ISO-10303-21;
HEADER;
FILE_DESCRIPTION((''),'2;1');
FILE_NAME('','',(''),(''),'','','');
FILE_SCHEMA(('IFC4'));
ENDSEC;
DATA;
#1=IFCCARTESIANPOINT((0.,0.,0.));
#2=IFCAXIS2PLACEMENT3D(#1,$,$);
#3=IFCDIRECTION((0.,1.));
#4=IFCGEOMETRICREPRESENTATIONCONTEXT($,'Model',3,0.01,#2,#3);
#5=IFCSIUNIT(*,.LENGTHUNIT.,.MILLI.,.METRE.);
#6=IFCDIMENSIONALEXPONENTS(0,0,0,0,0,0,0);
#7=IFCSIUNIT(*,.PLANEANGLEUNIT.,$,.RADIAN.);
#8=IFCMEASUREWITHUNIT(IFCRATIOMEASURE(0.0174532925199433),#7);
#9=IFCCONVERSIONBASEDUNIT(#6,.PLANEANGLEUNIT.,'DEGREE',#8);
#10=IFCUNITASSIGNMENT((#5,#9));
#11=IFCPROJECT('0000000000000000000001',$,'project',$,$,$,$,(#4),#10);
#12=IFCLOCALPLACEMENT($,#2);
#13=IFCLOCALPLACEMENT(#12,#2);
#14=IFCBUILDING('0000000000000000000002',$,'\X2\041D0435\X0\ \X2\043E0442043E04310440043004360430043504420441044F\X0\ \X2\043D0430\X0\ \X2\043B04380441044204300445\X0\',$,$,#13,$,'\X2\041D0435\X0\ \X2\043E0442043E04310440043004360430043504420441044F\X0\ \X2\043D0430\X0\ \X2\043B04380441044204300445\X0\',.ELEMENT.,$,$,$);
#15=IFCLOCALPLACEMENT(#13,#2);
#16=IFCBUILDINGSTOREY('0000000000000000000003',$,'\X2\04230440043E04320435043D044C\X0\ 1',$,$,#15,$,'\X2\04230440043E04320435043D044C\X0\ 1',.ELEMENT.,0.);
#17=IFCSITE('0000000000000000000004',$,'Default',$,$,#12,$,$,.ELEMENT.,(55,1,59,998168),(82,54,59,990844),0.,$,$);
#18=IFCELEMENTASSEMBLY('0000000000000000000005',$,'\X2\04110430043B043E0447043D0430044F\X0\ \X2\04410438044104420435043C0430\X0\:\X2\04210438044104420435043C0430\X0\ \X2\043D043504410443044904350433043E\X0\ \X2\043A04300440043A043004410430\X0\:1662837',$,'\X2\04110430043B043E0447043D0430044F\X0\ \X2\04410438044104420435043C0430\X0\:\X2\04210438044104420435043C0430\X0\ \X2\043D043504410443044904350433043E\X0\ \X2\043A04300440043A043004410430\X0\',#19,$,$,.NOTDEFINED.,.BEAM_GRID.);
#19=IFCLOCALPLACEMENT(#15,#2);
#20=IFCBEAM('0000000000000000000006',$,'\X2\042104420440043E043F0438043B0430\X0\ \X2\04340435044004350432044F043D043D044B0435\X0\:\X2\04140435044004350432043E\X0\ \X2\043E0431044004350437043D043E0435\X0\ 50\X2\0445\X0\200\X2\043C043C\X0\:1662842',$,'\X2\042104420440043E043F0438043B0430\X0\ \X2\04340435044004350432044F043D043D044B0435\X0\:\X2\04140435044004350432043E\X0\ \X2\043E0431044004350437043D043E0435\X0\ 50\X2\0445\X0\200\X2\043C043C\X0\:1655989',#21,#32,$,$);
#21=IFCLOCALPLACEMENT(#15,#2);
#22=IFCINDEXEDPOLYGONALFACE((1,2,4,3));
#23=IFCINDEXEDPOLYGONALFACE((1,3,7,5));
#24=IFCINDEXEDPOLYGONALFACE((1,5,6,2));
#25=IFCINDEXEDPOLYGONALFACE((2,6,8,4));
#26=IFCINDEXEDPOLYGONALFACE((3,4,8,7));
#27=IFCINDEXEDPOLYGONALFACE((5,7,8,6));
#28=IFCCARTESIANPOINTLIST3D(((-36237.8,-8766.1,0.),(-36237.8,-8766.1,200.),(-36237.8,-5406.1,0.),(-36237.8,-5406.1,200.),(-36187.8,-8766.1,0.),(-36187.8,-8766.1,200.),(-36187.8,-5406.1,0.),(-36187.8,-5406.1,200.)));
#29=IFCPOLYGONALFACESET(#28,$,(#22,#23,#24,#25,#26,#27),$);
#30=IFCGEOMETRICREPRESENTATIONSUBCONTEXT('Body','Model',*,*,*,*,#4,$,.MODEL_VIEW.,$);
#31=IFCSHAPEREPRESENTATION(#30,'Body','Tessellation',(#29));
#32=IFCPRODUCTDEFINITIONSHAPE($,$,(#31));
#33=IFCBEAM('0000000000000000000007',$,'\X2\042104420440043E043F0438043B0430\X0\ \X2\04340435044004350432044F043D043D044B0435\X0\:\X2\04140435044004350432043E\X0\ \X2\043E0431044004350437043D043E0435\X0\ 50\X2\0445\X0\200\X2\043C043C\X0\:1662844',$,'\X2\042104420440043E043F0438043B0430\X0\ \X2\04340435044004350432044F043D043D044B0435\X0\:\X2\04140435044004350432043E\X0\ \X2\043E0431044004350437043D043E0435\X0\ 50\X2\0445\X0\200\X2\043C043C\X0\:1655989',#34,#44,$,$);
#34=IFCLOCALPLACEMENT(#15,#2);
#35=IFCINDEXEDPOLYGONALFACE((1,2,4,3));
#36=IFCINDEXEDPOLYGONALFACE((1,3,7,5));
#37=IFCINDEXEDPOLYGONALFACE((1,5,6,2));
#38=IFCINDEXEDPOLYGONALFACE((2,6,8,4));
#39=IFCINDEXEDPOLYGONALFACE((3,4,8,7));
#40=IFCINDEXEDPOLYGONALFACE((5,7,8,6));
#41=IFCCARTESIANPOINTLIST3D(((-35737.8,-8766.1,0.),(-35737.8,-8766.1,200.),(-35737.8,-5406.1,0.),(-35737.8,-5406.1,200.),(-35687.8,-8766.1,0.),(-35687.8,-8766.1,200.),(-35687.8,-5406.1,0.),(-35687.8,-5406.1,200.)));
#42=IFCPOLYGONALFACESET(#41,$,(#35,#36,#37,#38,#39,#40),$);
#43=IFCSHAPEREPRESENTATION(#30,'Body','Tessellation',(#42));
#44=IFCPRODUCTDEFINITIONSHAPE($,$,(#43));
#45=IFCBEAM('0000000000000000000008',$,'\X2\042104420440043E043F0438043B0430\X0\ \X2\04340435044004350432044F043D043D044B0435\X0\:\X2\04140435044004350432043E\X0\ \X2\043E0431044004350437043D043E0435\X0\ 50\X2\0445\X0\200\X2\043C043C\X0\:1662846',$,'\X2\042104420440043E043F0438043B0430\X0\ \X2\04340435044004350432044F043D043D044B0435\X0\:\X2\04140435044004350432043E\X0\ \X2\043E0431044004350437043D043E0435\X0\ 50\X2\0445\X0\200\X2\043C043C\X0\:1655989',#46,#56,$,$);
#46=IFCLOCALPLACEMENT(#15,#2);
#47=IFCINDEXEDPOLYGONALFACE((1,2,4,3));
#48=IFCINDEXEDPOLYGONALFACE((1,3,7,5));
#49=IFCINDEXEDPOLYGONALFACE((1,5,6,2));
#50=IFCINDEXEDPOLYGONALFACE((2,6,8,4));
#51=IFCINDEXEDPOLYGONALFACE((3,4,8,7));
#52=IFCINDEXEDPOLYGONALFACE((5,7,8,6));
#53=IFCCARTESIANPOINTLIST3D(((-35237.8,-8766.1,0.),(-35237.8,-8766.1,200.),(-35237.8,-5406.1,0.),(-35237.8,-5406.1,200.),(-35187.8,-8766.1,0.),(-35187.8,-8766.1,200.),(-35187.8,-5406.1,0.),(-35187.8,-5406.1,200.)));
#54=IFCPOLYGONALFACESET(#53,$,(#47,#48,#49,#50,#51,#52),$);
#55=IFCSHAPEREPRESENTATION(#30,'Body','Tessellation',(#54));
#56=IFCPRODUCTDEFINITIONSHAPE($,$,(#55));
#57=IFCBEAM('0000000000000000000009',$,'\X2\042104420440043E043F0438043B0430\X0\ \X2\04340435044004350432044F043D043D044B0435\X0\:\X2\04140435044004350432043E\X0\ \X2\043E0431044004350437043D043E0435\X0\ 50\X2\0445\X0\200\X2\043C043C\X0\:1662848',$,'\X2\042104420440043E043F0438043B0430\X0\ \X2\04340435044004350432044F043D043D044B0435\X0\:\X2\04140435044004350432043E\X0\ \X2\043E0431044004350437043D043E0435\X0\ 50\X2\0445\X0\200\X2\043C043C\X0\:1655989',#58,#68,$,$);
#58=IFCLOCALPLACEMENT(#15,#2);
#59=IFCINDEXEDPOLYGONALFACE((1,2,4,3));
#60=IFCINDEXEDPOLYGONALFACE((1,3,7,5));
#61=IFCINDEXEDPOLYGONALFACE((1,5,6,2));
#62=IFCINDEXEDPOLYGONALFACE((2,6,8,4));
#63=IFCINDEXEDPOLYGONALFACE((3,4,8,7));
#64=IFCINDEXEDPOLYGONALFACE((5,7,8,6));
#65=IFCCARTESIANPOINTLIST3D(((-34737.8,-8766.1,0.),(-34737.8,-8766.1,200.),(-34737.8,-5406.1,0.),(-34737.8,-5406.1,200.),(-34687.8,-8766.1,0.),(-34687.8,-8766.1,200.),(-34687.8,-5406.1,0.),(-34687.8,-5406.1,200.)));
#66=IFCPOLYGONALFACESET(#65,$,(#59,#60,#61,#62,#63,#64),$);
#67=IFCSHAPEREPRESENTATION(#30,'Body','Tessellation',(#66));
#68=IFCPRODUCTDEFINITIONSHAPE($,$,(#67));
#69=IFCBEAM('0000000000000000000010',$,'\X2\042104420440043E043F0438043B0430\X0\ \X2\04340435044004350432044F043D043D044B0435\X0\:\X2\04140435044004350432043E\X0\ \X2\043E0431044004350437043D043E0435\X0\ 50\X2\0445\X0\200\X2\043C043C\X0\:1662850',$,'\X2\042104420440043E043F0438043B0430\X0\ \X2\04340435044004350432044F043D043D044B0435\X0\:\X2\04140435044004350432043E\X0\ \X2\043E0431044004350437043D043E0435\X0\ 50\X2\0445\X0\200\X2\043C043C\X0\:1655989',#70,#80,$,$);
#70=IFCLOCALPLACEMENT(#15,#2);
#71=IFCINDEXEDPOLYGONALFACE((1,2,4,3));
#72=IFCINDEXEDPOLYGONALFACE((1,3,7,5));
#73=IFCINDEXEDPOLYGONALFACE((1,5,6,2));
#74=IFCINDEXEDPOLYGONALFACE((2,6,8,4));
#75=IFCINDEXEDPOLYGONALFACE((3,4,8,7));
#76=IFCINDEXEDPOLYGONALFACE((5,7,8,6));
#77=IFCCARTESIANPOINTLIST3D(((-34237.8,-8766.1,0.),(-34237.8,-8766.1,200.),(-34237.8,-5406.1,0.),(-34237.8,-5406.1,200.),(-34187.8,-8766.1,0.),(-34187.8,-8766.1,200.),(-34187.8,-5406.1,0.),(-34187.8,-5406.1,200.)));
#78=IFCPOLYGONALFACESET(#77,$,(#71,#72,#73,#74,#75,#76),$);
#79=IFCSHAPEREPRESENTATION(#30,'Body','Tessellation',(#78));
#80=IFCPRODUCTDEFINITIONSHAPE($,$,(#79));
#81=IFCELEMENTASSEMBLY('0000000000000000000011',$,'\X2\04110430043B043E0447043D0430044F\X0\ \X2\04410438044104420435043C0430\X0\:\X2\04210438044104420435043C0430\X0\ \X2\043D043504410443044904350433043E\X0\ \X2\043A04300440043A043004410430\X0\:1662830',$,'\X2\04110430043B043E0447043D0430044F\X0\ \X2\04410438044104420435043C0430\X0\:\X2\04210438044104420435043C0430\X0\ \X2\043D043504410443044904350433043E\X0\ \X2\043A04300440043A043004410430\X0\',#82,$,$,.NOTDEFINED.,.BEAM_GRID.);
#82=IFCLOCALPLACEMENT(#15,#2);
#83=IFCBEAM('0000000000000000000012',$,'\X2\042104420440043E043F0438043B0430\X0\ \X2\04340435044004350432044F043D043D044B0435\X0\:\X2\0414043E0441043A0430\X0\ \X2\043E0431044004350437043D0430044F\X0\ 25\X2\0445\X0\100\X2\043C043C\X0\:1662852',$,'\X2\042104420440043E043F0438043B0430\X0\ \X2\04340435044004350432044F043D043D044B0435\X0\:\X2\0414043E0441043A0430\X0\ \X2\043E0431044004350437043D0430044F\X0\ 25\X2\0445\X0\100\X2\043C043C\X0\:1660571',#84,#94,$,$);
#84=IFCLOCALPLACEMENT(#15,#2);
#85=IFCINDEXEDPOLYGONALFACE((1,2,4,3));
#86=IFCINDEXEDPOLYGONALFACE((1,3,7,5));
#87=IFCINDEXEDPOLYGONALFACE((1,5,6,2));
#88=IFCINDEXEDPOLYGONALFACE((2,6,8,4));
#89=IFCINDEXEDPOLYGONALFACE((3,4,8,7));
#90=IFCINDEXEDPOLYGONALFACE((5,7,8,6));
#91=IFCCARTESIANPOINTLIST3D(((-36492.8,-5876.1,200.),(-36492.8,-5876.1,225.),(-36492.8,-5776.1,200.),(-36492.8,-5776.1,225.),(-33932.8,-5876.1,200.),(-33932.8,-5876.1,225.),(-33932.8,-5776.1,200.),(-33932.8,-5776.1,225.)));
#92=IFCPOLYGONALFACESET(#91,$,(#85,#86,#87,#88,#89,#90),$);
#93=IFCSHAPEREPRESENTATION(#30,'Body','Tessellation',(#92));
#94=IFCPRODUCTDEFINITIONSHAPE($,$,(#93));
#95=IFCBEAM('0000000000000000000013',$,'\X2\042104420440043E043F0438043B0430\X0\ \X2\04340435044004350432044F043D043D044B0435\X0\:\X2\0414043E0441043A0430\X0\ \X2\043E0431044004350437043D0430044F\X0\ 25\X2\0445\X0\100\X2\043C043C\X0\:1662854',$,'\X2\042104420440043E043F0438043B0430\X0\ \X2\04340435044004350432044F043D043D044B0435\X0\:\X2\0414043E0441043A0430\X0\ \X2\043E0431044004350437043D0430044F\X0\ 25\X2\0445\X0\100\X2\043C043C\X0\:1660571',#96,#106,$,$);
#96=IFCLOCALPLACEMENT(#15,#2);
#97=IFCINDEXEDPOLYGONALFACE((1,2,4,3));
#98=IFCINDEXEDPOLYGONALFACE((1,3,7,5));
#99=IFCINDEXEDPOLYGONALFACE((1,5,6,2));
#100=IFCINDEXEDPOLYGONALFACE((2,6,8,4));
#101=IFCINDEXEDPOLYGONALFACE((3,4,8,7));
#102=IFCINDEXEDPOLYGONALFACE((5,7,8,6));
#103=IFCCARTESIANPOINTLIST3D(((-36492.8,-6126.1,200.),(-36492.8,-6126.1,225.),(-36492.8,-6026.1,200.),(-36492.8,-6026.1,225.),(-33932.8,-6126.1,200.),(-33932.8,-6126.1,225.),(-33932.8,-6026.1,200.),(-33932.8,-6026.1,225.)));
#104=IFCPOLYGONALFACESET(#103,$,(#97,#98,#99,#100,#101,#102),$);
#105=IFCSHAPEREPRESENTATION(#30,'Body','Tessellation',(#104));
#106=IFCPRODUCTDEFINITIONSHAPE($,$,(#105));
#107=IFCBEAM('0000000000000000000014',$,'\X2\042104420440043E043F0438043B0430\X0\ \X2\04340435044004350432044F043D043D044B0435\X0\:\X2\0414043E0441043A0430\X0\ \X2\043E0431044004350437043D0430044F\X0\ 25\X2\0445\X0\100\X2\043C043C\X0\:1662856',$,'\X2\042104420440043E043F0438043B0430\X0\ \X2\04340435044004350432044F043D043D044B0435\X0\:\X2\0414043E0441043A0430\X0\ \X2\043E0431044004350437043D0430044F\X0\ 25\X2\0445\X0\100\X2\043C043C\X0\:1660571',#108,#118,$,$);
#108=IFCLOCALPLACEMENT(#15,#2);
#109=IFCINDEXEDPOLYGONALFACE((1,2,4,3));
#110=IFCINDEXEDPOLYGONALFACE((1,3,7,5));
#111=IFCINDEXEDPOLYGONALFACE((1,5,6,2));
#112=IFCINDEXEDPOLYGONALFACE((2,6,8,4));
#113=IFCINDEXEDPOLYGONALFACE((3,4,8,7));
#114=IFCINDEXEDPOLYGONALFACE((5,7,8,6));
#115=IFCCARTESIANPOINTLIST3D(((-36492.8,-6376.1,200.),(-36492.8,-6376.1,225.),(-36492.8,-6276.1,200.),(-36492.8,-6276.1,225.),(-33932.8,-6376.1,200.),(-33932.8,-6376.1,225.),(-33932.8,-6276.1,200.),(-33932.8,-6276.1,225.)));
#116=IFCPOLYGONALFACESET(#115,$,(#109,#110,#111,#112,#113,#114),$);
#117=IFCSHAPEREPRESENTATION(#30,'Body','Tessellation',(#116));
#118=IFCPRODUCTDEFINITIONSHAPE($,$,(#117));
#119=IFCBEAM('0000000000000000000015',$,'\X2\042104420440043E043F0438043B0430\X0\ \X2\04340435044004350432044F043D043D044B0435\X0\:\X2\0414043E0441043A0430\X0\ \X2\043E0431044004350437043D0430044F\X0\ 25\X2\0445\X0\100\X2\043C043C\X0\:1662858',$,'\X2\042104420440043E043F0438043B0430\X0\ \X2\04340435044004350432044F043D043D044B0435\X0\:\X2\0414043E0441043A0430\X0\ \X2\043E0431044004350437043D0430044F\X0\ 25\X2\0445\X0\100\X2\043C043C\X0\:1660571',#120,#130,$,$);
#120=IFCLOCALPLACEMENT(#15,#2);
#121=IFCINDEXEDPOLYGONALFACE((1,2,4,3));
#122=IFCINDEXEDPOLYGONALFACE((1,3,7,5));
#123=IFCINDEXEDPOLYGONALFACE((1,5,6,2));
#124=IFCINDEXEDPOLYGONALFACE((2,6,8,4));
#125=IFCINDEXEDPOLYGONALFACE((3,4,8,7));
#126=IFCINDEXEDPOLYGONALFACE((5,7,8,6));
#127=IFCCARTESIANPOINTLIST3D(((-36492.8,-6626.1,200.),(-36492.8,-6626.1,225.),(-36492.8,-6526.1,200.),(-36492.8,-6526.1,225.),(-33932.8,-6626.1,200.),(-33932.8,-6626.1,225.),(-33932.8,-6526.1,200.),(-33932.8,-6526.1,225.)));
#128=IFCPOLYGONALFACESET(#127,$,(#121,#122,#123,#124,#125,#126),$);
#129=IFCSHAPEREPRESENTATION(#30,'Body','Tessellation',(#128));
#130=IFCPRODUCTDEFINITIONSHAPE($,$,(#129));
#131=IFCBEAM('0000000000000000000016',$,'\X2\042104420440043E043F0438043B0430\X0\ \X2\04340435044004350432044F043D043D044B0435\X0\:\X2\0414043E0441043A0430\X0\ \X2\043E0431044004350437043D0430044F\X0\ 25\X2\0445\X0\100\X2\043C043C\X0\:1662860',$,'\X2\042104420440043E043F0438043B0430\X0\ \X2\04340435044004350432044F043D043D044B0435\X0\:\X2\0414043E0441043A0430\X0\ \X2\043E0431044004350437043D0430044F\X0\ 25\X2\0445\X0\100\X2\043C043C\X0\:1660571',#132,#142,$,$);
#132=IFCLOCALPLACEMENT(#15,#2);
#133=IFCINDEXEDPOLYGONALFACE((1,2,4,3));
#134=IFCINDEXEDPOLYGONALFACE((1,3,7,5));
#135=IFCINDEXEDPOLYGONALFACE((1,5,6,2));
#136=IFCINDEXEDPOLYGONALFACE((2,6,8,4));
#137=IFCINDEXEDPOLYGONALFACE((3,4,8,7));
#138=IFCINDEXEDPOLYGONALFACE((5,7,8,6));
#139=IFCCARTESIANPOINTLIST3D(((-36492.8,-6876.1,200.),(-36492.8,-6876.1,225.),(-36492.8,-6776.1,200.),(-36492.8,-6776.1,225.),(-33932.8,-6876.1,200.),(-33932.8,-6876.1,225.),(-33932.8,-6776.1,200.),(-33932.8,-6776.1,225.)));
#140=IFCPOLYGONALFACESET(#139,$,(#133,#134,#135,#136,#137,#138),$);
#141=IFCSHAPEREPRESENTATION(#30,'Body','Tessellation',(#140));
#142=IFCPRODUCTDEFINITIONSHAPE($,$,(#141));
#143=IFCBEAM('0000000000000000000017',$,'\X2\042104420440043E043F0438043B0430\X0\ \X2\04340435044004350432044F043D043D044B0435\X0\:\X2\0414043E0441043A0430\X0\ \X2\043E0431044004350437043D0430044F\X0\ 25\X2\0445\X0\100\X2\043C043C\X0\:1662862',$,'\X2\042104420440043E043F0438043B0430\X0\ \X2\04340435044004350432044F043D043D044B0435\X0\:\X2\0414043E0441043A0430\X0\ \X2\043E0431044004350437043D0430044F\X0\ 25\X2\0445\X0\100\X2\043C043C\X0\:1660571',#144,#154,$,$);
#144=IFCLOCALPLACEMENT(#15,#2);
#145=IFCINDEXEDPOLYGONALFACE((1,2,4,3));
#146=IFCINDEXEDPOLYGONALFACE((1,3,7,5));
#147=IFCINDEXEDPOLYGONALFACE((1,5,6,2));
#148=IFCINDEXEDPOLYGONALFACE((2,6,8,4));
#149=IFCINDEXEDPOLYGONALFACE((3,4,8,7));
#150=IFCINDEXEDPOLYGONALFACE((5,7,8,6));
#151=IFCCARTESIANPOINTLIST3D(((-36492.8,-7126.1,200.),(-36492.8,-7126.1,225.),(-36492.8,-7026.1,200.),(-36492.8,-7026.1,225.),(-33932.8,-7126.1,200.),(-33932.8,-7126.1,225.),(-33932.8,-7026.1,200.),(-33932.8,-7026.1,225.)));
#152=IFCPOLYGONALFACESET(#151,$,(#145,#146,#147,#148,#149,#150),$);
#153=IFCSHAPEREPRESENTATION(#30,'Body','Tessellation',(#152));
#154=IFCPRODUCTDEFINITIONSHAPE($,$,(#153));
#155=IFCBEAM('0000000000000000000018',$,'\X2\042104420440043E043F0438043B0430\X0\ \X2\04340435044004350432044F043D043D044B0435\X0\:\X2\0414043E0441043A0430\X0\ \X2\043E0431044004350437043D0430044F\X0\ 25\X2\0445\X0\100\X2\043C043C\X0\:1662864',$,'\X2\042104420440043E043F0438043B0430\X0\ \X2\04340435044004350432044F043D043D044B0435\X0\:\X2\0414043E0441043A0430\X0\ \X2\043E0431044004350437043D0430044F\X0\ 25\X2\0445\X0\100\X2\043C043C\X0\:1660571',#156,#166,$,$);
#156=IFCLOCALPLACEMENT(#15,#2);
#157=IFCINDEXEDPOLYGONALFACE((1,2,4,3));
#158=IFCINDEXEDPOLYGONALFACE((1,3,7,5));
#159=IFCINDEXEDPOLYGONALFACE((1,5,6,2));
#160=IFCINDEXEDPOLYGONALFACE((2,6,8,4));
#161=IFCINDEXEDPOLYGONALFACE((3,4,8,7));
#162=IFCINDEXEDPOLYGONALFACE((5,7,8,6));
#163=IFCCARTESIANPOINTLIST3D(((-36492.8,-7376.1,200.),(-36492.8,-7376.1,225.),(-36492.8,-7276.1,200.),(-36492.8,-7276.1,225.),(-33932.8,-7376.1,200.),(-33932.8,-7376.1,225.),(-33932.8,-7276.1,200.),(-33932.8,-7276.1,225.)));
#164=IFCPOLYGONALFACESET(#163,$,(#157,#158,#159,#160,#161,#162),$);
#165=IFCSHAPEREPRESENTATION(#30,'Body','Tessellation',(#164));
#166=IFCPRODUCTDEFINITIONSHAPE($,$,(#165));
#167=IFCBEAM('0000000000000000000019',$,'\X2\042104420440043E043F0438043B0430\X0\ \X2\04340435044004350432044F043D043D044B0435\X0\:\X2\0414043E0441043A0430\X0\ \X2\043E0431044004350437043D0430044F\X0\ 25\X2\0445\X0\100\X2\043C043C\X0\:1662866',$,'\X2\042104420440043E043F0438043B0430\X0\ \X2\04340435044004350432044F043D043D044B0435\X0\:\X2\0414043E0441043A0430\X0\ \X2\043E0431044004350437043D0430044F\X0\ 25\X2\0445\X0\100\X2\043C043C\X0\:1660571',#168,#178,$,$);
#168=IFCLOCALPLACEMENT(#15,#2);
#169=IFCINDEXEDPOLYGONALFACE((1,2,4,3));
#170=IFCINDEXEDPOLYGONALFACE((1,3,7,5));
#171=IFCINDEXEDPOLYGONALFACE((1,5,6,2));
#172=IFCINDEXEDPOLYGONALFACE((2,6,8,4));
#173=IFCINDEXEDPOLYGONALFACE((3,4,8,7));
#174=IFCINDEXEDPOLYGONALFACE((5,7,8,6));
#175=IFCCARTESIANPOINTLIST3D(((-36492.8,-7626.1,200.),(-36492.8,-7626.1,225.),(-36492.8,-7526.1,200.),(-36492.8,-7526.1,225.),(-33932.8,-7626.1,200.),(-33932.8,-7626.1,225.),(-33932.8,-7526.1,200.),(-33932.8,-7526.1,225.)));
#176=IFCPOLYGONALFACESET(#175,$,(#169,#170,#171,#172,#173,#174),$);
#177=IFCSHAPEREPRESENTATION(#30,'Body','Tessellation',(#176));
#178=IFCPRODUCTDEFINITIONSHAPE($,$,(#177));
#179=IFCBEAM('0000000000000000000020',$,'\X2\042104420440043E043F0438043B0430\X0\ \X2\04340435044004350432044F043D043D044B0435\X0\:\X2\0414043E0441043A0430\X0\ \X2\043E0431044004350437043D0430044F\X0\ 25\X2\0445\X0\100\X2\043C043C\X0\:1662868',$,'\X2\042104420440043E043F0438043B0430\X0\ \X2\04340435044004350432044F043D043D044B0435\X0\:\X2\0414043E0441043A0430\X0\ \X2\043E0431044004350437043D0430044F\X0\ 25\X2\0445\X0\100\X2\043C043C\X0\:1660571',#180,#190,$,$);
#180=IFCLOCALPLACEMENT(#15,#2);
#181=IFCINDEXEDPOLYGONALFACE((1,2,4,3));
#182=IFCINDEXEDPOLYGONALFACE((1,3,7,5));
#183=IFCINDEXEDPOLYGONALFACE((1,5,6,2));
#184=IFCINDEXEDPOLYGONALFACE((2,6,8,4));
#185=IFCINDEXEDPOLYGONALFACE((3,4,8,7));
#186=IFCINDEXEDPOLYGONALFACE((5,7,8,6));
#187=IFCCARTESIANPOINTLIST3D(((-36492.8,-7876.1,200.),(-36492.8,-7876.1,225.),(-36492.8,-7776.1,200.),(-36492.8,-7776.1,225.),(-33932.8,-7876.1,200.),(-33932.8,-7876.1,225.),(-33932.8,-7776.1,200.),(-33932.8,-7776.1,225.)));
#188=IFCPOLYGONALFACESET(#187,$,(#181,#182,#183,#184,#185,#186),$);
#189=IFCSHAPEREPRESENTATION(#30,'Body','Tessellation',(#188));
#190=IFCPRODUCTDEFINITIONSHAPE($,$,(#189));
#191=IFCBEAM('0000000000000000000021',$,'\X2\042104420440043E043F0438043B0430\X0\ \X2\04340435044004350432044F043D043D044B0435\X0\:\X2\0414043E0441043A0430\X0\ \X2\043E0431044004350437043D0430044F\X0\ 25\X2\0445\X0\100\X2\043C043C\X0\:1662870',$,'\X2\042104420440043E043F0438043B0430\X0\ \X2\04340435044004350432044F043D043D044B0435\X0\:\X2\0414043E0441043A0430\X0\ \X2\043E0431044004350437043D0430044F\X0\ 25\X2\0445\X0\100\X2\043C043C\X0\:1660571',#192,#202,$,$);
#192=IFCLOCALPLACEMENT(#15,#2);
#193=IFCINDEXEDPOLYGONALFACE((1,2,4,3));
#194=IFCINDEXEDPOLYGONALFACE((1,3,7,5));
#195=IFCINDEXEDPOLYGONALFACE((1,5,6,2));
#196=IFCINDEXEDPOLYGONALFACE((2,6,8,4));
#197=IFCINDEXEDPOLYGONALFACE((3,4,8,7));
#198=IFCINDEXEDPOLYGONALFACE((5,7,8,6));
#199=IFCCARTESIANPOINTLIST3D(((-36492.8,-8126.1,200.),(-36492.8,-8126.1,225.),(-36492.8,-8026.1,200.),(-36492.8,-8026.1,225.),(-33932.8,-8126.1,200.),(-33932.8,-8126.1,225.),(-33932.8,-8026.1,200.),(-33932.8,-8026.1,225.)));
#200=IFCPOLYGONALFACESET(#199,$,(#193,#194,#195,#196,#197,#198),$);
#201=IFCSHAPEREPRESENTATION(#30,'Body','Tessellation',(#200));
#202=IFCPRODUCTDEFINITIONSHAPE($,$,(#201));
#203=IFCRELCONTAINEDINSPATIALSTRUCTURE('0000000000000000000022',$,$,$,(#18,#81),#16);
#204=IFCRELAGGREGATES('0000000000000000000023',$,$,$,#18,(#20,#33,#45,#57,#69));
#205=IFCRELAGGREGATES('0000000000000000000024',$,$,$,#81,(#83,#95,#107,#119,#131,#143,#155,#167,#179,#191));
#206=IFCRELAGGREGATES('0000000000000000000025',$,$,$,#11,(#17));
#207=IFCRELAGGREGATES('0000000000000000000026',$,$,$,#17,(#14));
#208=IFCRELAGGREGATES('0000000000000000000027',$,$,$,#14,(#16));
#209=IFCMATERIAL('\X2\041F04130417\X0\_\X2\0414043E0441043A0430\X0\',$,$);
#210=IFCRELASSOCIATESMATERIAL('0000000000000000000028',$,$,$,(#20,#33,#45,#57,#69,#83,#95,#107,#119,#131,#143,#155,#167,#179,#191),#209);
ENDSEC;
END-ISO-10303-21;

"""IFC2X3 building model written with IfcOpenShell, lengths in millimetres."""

from ifc_helpers import new_model, entity, si_unit, converted_unit, direction, frame, frame_2d, origin, place, context, subcontext, project, spatial, rectangle, extrude, material, element, aggregate, save


model = new_model("IFC2X3")

# Units and contexts
model_context = context("Model", 3, precision=0.01, world=origin(), true_north=direction((0.0, 1.0)))
body_context = subcontext(model_context, "Body", "Model", "MODEL_VIEW")
ifc_project = project(units=[si_unit("LENGTHUNIT", "METRE", prefix="MILLI"), converted_unit("PLANEANGLEUNIT", "DEGREE", entity("IfcRatioMeasure", 0.0174532925199433), si_unit("PLANEANGLEUNIT", "RADIAN"), dimensions=[0, 0, 0, 0, 0, 0, 0])], contexts=[model_context])

# Site, building, storey
site_placement = place(None, origin())
site = spatial("IfcSite", under=ifc_project, at=site_placement, Name="Default", CompositionType="ELEMENT", RefLatitude=(55, 1, 59, 998168), RefLongitude=(82, 54, 59, 990844), RefElevation=0.0)
building_placement = place(site_placement, origin())
building = spatial("IfcBuilding", under=site, at=building_placement, Name="Не отображается на листах", LongName="Не отображается на листах", CompositionType="ELEMENT")
storey_placement = place(building_placement, frame((0.0, 0.0, 0.0)))
storey = spatial("IfcBuildingStorey", under=building, at=storey_placement, Name="Уровень 1", LongName="Уровень 1", CompositionType="ELEMENT", Elevation=0.0)

# Element assemblies, beams
assembly_1_placement = place(storey_placement, origin())
assembly_1 = element("IfcElementAssembly", 1, at=assembly_1_placement, inside=storey, Name="Балочная система:Система несущего каркаса:1662837", ObjectType="Балочная система:Система несущего каркаса", AssemblyPlace="NOTDEFINED", PredefinedType="BEAM_GRID")
ifc_material_1 = material(Name="ПГЗ_Доска")
beam_1_placement = place(assembly_1_placement, frame((-36212.8, -8766.1, 0.0), z_axis=(0.0, 0.0, 1.0), x_axis=(0.0, 1.0, 0.0)))
beam_1 = element("IfcBeam", 2, at=beam_1_placement, material=ifc_material_1, Name="Стропила деревянные:Дерево обрезное 50х200мм:1662842", ObjectType="Стропила деревянные:Дерево обрезное 50х200мм:1655989", context=body_context, shape_type="SweptSolid", body=[
    extrude(rectangle(XDim=200.0, YDim=50.0, at=frame_2d((0.0, 0.0), x_axis=(1.0, 0.0))), frame((0.0, 0.0, 100.0), z_axis=(1.0, 0.0, 0.0), x_axis=(0.0, 0.0, -1.0)), (0.0, 0.0, 1.0), 3360.0),
])
beam_2_placement = place(assembly_1_placement, frame((-35712.8, -8766.1, 0.0), z_axis=(0.0, 0.0, 1.0), x_axis=(0.0, 1.0, 0.0)))
beam_2 = element("IfcBeam", 3, at=beam_2_placement, material=ifc_material_1, Name="Стропила деревянные:Дерево обрезное 50х200мм:1662844", ObjectType="Стропила деревянные:Дерево обрезное 50х200мм:1655989", context=body_context, shape_type="SweptSolid", body=[
    extrude(rectangle(XDim=200.0, YDim=50.0, at=frame_2d((0.0, 0.0), x_axis=(1.0, 0.0))), frame((0.0, 0.0, 100.0), z_axis=(1.0, 0.0, 0.0), x_axis=(0.0, 0.0, -1.0)), (0.0, 0.0, 1.0), 3360.0),
])
beam_3_placement = place(assembly_1_placement, frame((-35212.8, -8766.1, 0.0), z_axis=(0.0, 0.0, 1.0), x_axis=(0.0, 1.0, 0.0)))
beam_3 = element("IfcBeam", 4, at=beam_3_placement, material=ifc_material_1, Name="Стропила деревянные:Дерево обрезное 50х200мм:1662846", ObjectType="Стропила деревянные:Дерево обрезное 50х200мм:1655989", context=body_context, shape_type="SweptSolid", body=[
    extrude(rectangle(XDim=200.0, YDim=50.0, at=frame_2d((0.0, 0.0), x_axis=(1.0, 0.0))), frame((0.0, 0.0, 100.0), z_axis=(1.0, 0.0, 0.0), x_axis=(0.0, 0.0, -1.0)), (0.0, 0.0, 1.0), 3360.0),
])
beam_4_placement = place(assembly_1_placement, frame((-34712.8, -8766.1, 0.0), z_axis=(0.0, 0.0, 1.0), x_axis=(0.0, 1.0, 0.0)))
beam_4 = element("IfcBeam", 5, at=beam_4_placement, material=ifc_material_1, Name="Стропила деревянные:Дерево обрезное 50х200мм:1662848", ObjectType="Стропила деревянные:Дерево обрезное 50х200мм:1655989", context=body_context, shape_type="SweptSolid", body=[
    extrude(rectangle(XDim=200.0, YDim=50.0, at=frame_2d((0.0, 0.0), x_axis=(1.0, 0.0))), frame((0.0, 0.0, 100.0), z_axis=(1.0, 0.0, 0.0), x_axis=(0.0, 0.0, -1.0)), (0.0, 0.0, 1.0), 3360.0),
])
beam_5_placement = place(assembly_1_placement, frame((-34212.8, -8766.1, 0.0), z_axis=(0.0, 0.0, 1.0), x_axis=(0.0, 1.0, 0.0)))
beam_5 = element("IfcBeam", 6, at=beam_5_placement, material=ifc_material_1, Name="Стропила деревянные:Дерево обрезное 50х200мм:1662850", ObjectType="Стропила деревянные:Дерево обрезное 50х200мм:1655989", context=body_context, shape_type="SweptSolid", body=[
    extrude(rectangle(XDim=200.0, YDim=50.0, at=frame_2d((0.0, 0.0), x_axis=(1.0, 0.0))), frame((0.0, 0.0, 100.0), z_axis=(1.0, 0.0, 0.0), x_axis=(0.0, 0.0, -1.0)), (0.0, 0.0, 1.0), 3360.0),
])
aggregate(assembly_1, [beam_1, beam_2, beam_3, beam_4, beam_5])
assembly_2_placement = place(storey_placement, origin())
assembly_2 = element("IfcElementAssembly", 7, at=assembly_2_placement, inside=storey, Name="Балочная система:Система несущего каркаса:1662830", ObjectType="Балочная система:Система несущего каркаса", AssemblyPlace="NOTDEFINED", PredefinedType="BEAM_GRID")
beam_6_placement = place(assembly_2_placement, frame((-36492.8, -5826.1, 0.0)))
beam_6 = element("IfcBeam", 8, at=beam_6_placement, material=ifc_material_1, Name="Стропила деревянные:Доска обрезная 25х100мм:1662852", ObjectType="Стропила деревянные:Доска обрезная 25х100мм:1660571", context=body_context, shape_type="SweptSolid", body=[
    extrude(rectangle(XDim=25.0, YDim=100.0, at=frame_2d((0.0, 0.0), x_axis=(1.0, 0.0))), frame((0.0, 0.0, 212.5), z_axis=(1.0, 0.0, 0.0), x_axis=(0.0, 0.0, -1.0)), (0.0, 0.0, 1.0), 2560.0),
])
beam_7_placement = place(assembly_2_placement, frame((-36492.8, -6076.1, 0.0)))
beam_7 = element("IfcBeam", 9, at=beam_7_placement, material=ifc_material_1, Name="Стропила деревянные:Доска обрезная 25х100мм:1662854", ObjectType="Стропила деревянные:Доска обрезная 25х100мм:1660571", context=body_context, shape_type="SweptSolid", body=[
    extrude(rectangle(XDim=25.0, YDim=100.0, at=frame_2d((0.0, 0.0), x_axis=(1.0, 0.0))), frame((0.0, 0.0, 212.5), z_axis=(1.0, 0.0, 0.0), x_axis=(0.0, 0.0, -1.0)), (0.0, 0.0, 1.0), 2560.0),
])
beam_8_placement = place(assembly_2_placement, frame((-36492.8, -6326.1, 0.0)))
beam_8 = element("IfcBeam", 10, at=beam_8_placement, material=ifc_material_1, Name="Стропила деревянные:Доска обрезная 25х100мм:1662856", ObjectType="Стропила деревянные:Доска обрезная 25х100мм:1660571", context=body_context, shape_type="SweptSolid", body=[
    extrude(rectangle(XDim=25.0, YDim=100.0, at=frame_2d((0.0, 0.0), x_axis=(1.0, 0.0))), frame((0.0, 0.0, 212.5), z_axis=(1.0, 0.0, 0.0), x_axis=(0.0, 0.0, -1.0)), (0.0, 0.0, 1.0), 2560.0),
])
beam_9_placement = place(assembly_2_placement, frame((-36492.8, -6576.1, 0.0)))
beam_9 = element("IfcBeam", 11, at=beam_9_placement, material=ifc_material_1, Name="Стропила деревянные:Доска обрезная 25х100мм:1662858", ObjectType="Стропила деревянные:Доска обрезная 25х100мм:1660571", context=body_context, shape_type="SweptSolid", body=[
    extrude(rectangle(XDim=25.0, YDim=100.0, at=frame_2d((0.0, 0.0), x_axis=(1.0, 0.0))), frame((0.0, 0.0, 212.5), z_axis=(1.0, 0.0, 0.0), x_axis=(0.0, 0.0, -1.0)), (0.0, 0.0, 1.0), 2560.0),
])
beam_10_placement = place(assembly_2_placement, frame((-36492.8, -6826.1, 0.0)))
beam_10 = element("IfcBeam", 12, at=beam_10_placement, material=ifc_material_1, Name="Стропила деревянные:Доска обрезная 25х100мм:1662860", ObjectType="Стропила деревянные:Доска обрезная 25х100мм:1660571", context=body_context, shape_type="SweptSolid", body=[
    extrude(rectangle(XDim=25.0, YDim=100.0, at=frame_2d((0.0, 0.0), x_axis=(1.0, 0.0))), frame((0.0, 0.0, 212.5), z_axis=(1.0, 0.0, 0.0), x_axis=(0.0, 0.0, -1.0)), (0.0, 0.0, 1.0), 2560.0),
])
beam_11_placement = place(assembly_2_placement, frame((-36492.8, -7076.1, 0.0)))
beam_11 = element("IfcBeam", 13, at=beam_11_placement, material=ifc_material_1, Name="Стропила деревянные:Доска обрезная 25х100мм:1662862", ObjectType="Стропила деревянные:Доска обрезная 25х100мм:1660571", context=body_context, shape_type="SweptSolid", body=[
    extrude(rectangle(XDim=25.0, YDim=100.0, at=frame_2d((0.0, 0.0), x_axis=(1.0, 0.0))), frame((0.0, 0.0, 212.5), z_axis=(1.0, 0.0, 0.0), x_axis=(0.0, 0.0, -1.0)), (0.0, 0.0, 1.0), 2560.0),
])
beam_12_placement = place(assembly_2_placement, frame((-36492.8, -7326.1, 0.0)))
beam_12 = element("IfcBeam", 14, at=beam_12_placement, material=ifc_material_1, Name="Стропила деревянные:Доска обрезная 25х100мм:1662864", ObjectType="Стропила деревянные:Доска обрезная 25х100мм:1660571", context=body_context, shape_type="SweptSolid", body=[
    extrude(rectangle(XDim=25.0, YDim=100.0, at=frame_2d((0.0, 0.0), x_axis=(1.0, 0.0))), frame((0.0, 0.0, 212.5), z_axis=(1.0, 0.0, 0.0), x_axis=(0.0, 0.0, -1.0)), (0.0, 0.0, 1.0), 2560.0),
])
beam_13_placement = place(assembly_2_placement, frame((-36492.8, -7576.1, 0.0)))
beam_13 = element("IfcBeam", 15, at=beam_13_placement, material=ifc_material_1, Name="Стропила деревянные:Доска обрезная 25х100мм:1662866", ObjectType="Стропила деревянные:Доска обрезная 25х100мм:1660571", context=body_context, shape_type="SweptSolid", body=[
    extrude(rectangle(XDim=25.0, YDim=100.0, at=frame_2d((0.0, 0.0), x_axis=(1.0, 0.0))), frame((0.0, 0.0, 212.5), z_axis=(1.0, 0.0, 0.0), x_axis=(0.0, 0.0, -1.0)), (0.0, 0.0, 1.0), 2560.0),
])
beam_14_placement = place(assembly_2_placement, frame((-36492.8, -7826.1, 0.0)))
beam_14 = element("IfcBeam", 16, at=beam_14_placement, material=ifc_material_1, Name="Стропила деревянные:Доска обрезная 25х100мм:1662868", ObjectType="Стропила деревянные:Доска обрезная 25х100мм:1660571", context=body_context, shape_type="SweptSolid", body=[
    extrude(rectangle(XDim=25.0, YDim=100.0, at=frame_2d((0.0, 0.0), x_axis=(1.0, 0.0))), frame((0.0, 0.0, 212.5), z_axis=(1.0, 0.0, 0.0), x_axis=(0.0, 0.0, -1.0)), (0.0, 0.0, 1.0), 2560.0),
])
beam_15_placement = place(assembly_2_placement, frame((-36492.8, -8076.1, 0.0)))
beam_15 = element("IfcBeam", 17, at=beam_15_placement, material=ifc_material_1, Name="Стропила деревянные:Доска обрезная 25х100мм:1662870", ObjectType="Стропила деревянные:Доска обрезная 25х100мм:1660571", context=body_context, shape_type="SweptSolid", body=[
    extrude(rectangle(XDim=25.0, YDim=100.0, at=frame_2d((0.0, 0.0), x_axis=(1.0, 0.0))), frame((0.0, 0.0, 212.5), z_axis=(1.0, 0.0, 0.0), x_axis=(0.0, 0.0, -1.0)), (0.0, 0.0, 1.0), 2560.0),
])
aggregate(assembly_2, [beam_6, beam_7, beam_8, beam_9, beam_10, beam_11, beam_12, beam_13, beam_14, beam_15])

save(model, "model.ifc")
